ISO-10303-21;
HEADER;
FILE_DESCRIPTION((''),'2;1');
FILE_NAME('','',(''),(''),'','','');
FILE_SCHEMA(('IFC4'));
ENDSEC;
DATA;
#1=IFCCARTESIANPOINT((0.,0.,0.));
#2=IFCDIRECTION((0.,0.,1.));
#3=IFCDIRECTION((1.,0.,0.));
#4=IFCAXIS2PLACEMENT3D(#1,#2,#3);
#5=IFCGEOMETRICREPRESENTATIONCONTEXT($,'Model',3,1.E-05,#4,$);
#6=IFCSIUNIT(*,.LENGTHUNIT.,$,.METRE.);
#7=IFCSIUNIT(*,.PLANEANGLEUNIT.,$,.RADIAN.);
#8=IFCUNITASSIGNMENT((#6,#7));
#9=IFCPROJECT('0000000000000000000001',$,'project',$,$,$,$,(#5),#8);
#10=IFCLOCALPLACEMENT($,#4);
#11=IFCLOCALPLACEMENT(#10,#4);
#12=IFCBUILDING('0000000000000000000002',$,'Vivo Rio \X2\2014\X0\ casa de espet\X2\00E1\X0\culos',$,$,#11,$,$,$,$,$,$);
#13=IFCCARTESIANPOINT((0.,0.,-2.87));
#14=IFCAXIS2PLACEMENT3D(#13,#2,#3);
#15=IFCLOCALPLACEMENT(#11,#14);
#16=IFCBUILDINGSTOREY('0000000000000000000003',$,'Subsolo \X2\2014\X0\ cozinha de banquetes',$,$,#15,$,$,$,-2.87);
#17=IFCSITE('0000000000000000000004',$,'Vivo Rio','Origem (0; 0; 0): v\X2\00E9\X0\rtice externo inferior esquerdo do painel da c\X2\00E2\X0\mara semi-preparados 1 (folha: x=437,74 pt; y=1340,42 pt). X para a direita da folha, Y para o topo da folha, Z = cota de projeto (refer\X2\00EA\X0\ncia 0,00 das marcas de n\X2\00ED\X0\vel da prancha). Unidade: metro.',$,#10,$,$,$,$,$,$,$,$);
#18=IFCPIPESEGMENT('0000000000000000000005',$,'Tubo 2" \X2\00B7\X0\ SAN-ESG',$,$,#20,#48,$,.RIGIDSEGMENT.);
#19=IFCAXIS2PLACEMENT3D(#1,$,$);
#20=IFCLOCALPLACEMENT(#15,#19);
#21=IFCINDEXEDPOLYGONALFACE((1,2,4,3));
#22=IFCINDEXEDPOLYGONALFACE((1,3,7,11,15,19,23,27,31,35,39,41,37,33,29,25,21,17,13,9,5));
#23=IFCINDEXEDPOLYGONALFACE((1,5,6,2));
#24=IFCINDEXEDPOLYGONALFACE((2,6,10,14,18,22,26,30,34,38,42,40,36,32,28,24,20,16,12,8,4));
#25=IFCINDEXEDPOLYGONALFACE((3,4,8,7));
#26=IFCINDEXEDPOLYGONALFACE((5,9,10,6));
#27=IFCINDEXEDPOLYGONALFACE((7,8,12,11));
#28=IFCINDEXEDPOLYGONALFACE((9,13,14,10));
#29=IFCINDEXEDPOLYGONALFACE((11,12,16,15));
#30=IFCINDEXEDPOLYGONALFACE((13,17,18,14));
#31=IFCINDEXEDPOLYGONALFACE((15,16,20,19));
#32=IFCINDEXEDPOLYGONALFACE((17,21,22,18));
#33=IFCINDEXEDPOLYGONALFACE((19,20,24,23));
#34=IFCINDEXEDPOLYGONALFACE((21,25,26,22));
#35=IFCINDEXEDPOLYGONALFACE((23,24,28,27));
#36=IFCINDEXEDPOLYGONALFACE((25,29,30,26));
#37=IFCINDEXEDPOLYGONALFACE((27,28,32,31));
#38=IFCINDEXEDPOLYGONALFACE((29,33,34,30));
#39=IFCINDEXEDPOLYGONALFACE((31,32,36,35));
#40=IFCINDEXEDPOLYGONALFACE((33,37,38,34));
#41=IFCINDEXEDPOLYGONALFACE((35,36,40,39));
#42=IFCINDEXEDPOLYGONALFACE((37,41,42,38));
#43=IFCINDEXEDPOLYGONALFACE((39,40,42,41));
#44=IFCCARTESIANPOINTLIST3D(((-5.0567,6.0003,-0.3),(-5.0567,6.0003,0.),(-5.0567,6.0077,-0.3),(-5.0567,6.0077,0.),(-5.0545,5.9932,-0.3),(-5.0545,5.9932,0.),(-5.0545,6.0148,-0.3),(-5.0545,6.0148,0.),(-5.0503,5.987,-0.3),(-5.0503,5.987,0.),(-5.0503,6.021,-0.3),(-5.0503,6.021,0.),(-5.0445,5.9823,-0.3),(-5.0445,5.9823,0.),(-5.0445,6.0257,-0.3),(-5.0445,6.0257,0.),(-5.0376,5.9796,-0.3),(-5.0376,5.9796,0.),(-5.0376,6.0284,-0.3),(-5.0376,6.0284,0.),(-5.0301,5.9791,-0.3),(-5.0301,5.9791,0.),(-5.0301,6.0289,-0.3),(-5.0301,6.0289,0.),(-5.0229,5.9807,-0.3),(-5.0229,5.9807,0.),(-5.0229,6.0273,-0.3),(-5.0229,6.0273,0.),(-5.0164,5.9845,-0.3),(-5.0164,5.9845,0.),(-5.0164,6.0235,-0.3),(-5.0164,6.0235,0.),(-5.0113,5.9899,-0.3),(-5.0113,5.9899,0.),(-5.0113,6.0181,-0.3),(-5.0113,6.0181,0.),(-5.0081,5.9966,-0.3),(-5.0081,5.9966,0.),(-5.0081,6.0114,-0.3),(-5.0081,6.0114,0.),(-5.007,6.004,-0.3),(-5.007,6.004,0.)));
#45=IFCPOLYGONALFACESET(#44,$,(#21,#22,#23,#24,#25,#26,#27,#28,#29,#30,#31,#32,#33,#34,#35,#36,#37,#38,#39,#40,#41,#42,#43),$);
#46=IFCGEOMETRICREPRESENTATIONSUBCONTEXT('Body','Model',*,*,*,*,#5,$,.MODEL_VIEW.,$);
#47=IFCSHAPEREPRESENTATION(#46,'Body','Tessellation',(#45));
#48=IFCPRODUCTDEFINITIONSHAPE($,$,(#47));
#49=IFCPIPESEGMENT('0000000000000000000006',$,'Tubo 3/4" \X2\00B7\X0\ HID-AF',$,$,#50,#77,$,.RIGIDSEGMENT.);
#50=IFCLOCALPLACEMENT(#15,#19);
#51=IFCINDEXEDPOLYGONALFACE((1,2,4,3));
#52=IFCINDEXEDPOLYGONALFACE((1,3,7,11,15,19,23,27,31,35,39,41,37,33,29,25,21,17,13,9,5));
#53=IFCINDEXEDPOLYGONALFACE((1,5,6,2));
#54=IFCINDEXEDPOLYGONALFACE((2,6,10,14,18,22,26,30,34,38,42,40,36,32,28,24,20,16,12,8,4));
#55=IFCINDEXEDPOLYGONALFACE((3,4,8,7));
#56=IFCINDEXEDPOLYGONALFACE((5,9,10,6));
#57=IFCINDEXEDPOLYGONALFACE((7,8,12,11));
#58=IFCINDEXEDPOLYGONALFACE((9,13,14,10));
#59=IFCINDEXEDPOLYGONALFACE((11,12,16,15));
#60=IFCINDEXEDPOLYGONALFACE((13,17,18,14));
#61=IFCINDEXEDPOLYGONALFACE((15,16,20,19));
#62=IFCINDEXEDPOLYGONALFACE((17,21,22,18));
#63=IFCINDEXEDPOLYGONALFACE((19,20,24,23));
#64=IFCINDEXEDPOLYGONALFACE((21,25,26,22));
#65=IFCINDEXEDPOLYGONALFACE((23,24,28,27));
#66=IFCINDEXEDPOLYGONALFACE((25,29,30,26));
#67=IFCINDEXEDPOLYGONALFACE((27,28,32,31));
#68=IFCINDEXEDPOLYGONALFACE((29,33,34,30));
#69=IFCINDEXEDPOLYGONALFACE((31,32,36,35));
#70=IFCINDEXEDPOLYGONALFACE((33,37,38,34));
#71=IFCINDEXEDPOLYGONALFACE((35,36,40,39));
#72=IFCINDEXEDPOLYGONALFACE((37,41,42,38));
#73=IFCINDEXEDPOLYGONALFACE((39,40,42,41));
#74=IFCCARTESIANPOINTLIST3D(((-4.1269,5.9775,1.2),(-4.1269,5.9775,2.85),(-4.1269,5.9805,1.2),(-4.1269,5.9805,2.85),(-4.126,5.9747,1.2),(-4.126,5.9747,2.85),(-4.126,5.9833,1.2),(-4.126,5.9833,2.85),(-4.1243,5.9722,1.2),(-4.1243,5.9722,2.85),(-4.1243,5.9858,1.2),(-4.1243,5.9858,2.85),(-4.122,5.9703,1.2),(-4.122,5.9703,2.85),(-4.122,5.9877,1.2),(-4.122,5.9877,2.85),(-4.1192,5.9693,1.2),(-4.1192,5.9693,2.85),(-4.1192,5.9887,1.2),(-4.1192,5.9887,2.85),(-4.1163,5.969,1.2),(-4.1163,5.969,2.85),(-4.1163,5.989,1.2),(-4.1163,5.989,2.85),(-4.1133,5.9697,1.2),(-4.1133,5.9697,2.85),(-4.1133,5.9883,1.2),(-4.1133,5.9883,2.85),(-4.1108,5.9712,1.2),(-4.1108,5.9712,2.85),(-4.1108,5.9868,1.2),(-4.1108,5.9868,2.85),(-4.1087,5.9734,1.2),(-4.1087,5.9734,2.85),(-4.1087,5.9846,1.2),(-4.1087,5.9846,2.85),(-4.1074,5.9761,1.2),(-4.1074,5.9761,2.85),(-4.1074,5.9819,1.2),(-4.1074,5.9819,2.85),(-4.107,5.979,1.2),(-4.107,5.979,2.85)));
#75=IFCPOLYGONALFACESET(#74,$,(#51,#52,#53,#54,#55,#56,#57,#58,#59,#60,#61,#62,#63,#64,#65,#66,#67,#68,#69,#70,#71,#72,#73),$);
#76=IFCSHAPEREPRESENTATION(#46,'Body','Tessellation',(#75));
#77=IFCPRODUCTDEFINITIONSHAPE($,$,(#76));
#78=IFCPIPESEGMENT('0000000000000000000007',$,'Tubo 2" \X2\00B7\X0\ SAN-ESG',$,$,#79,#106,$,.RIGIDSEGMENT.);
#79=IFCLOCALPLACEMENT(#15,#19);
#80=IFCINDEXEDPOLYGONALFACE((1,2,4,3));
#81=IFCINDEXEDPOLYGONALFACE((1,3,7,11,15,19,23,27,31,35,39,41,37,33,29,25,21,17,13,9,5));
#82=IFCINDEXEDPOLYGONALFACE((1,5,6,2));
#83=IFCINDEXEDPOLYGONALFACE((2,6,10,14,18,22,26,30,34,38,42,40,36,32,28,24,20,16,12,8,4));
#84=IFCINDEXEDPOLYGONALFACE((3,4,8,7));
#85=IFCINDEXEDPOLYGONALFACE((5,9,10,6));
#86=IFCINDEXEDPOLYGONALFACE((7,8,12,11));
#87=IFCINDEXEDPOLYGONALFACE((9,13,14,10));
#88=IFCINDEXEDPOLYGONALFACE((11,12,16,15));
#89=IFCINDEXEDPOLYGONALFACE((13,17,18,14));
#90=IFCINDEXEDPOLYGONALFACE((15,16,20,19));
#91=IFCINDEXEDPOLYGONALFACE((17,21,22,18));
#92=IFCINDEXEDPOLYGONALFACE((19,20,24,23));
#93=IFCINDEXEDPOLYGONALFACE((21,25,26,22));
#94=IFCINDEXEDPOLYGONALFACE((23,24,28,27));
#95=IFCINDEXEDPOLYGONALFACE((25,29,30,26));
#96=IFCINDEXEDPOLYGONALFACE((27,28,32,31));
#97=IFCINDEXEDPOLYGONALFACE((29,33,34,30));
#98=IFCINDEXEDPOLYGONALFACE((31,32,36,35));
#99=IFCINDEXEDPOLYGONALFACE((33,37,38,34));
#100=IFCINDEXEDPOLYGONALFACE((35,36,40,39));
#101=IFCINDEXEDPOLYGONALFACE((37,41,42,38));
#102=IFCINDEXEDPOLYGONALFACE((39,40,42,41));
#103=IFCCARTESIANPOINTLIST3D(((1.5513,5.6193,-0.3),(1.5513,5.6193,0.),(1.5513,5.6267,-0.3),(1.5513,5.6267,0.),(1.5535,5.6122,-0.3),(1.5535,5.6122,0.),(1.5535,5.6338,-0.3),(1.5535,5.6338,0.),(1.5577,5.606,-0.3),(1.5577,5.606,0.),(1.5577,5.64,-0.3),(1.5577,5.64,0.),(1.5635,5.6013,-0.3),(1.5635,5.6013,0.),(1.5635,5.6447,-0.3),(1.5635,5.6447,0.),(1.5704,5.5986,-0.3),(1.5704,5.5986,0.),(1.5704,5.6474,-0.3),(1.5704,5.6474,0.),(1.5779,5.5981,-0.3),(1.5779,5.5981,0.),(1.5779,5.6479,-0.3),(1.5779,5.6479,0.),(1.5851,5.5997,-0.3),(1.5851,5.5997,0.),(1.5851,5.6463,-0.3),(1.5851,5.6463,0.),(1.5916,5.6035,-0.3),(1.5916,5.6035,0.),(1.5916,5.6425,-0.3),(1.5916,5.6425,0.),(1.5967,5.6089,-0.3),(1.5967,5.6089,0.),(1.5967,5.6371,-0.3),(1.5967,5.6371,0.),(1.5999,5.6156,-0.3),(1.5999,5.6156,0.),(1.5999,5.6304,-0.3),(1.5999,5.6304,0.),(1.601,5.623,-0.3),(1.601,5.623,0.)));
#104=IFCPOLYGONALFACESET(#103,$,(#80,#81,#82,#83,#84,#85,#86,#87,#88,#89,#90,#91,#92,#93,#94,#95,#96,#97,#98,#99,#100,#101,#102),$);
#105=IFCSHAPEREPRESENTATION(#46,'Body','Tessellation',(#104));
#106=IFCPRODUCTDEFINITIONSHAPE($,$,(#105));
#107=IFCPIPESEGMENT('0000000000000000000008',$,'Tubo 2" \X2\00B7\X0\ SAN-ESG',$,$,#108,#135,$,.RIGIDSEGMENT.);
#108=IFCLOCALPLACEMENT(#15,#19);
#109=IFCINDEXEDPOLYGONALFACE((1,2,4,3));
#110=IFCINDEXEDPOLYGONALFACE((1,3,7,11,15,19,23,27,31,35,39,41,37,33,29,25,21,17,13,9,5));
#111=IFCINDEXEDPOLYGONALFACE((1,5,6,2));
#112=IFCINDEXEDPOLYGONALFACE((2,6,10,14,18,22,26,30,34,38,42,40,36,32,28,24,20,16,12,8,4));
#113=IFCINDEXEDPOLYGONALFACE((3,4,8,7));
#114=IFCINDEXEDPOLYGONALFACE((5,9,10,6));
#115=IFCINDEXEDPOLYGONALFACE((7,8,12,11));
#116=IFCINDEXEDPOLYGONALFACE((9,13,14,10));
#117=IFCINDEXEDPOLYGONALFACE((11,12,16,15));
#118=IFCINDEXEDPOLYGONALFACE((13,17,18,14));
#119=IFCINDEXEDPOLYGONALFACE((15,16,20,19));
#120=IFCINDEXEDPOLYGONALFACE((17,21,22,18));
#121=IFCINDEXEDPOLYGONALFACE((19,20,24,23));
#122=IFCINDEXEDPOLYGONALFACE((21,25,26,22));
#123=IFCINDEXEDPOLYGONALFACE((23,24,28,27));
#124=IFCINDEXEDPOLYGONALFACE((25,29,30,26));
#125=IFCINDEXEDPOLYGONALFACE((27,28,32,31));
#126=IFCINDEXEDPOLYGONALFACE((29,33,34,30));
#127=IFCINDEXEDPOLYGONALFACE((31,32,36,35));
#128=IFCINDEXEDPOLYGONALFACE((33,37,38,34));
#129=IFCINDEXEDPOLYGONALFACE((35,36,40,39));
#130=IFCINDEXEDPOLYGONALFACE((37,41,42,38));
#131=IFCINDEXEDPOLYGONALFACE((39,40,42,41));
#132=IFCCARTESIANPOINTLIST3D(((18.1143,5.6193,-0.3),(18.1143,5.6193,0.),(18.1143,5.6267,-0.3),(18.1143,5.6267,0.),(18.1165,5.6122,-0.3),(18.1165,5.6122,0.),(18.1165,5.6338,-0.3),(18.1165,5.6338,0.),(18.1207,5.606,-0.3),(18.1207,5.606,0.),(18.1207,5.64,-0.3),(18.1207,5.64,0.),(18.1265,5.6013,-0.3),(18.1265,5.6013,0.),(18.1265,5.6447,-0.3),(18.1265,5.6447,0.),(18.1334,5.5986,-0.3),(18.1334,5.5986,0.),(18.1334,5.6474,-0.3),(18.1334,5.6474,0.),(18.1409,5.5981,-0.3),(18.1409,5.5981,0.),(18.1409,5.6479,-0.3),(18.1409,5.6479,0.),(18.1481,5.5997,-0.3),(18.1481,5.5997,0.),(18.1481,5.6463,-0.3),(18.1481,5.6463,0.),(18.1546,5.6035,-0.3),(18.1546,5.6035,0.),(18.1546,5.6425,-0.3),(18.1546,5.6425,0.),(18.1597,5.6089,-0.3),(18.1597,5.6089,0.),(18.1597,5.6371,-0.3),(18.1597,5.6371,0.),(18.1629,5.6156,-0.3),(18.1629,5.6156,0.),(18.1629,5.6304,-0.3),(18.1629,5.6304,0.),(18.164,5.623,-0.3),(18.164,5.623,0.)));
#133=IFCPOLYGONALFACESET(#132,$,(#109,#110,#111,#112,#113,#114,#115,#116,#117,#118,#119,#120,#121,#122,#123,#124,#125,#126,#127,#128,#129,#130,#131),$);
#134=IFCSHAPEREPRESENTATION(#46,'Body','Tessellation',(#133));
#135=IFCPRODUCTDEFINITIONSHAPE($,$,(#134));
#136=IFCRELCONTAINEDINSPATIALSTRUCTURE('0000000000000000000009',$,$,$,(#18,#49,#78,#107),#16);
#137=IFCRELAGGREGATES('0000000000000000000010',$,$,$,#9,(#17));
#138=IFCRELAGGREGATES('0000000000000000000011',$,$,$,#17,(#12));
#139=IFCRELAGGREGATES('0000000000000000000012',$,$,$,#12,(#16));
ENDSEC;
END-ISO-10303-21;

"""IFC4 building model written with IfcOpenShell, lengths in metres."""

from ifc_helpers import new_model, si_unit, frame, origin_with_axes, origin_2d, place, context, subcontext, project, spatial, circle, extrude, element, save


model = new_model("IFC4")

# Units and contexts
model_context = context("Model", 3, precision=1e-05, world=origin_with_axes())
body_context = subcontext(model_context, "Body", "Model", "MODEL_VIEW")
ifc_project = project(units=[si_unit("LENGTHUNIT", "METRE"), si_unit("PLANEANGLEUNIT", "RADIAN")], contexts=[model_context])

# Site, building, storey
site_placement = place(None, origin_with_axes())
site = spatial("IfcSite", under=ifc_project, at=site_placement, Name="Vivo Rio", Description="Origem (0; 0; 0): vértice externo inferior esquerdo do painel da câmara semi-preparados 1 (folha: x=437,74 pt; y=1340,42 pt). X para a direita da folha, Y para o topo da folha, Z = cota de projeto (referência 0,00 das marcas de nível da prancha). Unidade: metro.")
building_placement = place(site_placement, origin_with_axes())
building = spatial("IfcBuilding", under=site, at=building_placement, Name="Vivo Rio — casa de espetáculos")
storey_placement = place(building_placement, frame((0.0, 0.0, -2.87), z_axis=(0.0, 0.0, 1.0), x_axis=(1.0, 0.0, 0.0)))
storey = spatial("IfcBuildingStorey", under=building, at=storey_placement, Name="Subsolo — cozinha de banquetes", Elevation=-2.87)

# Pipe segments
pipe_segment_1_placement = place(storey_placement, origin_with_axes())
element("IfcPipeSegment", 1, at=pipe_segment_1_placement, inside=storey, Name="Tubo 2\" · SAN-ESG", PredefinedType="RIGIDSEGMENT", context=body_context, shape_type="SweptSolid", body=[
    extrude(circle(Radius=0.025, at=origin_2d()), frame((-5.032, 6.004, 0.0), z_axis=(0.0, 0.0, -1.0), x_axis=(1.0, 0.0, 0.0)), (0.0, 0.0, 1.0), 0.3),
])
pipe_segment_2_placement = place(storey_placement, origin_with_axes())
element("IfcPipeSegment", 2, at=pipe_segment_2_placement, inside=storey, Name="Tubo 3/4\" · HID-AF", PredefinedType="RIGIDSEGMENT", context=body_context, shape_type="SweptSolid", body=[
    extrude(circle(Radius=0.01, at=origin_2d()), frame((-4.117, 5.979, 2.85), z_axis=(0.0, 0.0, -1.0), x_axis=(1.0, 0.0, 0.0)), (0.0, 0.0, 1.0), 1.65),
])
pipe_segment_3_placement = place(storey_placement, origin_with_axes())
element("IfcPipeSegment", 3, at=pipe_segment_3_placement, inside=storey, Name="Tubo 2\" · SAN-ESG", PredefinedType="RIGIDSEGMENT", context=body_context, shape_type="SweptSolid", body=[
    extrude(circle(Radius=0.025, at=origin_2d()), frame((1.576, 5.623, 0.0), z_axis=(0.0, 0.0, -1.0), x_axis=(1.0, 0.0, 0.0)), (0.0, 0.0, 1.0), 0.3),
])
pipe_segment_4_placement = place(storey_placement, origin_with_axes())
element("IfcPipeSegment", 4, at=pipe_segment_4_placement, inside=storey, Name="Tubo 2\" · SAN-ESG", PredefinedType="RIGIDSEGMENT", context=body_context, shape_type="SweptSolid", body=[
    extrude(circle(Radius=0.025, at=origin_2d()), frame((18.139, 5.623, 0.0), z_axis=(0.0, 0.0, -1.0), x_axis=(1.0, 0.0, 0.0)), (0.0, 0.0, 1.0), 0.3),
])

save(model, "model.ifc")
